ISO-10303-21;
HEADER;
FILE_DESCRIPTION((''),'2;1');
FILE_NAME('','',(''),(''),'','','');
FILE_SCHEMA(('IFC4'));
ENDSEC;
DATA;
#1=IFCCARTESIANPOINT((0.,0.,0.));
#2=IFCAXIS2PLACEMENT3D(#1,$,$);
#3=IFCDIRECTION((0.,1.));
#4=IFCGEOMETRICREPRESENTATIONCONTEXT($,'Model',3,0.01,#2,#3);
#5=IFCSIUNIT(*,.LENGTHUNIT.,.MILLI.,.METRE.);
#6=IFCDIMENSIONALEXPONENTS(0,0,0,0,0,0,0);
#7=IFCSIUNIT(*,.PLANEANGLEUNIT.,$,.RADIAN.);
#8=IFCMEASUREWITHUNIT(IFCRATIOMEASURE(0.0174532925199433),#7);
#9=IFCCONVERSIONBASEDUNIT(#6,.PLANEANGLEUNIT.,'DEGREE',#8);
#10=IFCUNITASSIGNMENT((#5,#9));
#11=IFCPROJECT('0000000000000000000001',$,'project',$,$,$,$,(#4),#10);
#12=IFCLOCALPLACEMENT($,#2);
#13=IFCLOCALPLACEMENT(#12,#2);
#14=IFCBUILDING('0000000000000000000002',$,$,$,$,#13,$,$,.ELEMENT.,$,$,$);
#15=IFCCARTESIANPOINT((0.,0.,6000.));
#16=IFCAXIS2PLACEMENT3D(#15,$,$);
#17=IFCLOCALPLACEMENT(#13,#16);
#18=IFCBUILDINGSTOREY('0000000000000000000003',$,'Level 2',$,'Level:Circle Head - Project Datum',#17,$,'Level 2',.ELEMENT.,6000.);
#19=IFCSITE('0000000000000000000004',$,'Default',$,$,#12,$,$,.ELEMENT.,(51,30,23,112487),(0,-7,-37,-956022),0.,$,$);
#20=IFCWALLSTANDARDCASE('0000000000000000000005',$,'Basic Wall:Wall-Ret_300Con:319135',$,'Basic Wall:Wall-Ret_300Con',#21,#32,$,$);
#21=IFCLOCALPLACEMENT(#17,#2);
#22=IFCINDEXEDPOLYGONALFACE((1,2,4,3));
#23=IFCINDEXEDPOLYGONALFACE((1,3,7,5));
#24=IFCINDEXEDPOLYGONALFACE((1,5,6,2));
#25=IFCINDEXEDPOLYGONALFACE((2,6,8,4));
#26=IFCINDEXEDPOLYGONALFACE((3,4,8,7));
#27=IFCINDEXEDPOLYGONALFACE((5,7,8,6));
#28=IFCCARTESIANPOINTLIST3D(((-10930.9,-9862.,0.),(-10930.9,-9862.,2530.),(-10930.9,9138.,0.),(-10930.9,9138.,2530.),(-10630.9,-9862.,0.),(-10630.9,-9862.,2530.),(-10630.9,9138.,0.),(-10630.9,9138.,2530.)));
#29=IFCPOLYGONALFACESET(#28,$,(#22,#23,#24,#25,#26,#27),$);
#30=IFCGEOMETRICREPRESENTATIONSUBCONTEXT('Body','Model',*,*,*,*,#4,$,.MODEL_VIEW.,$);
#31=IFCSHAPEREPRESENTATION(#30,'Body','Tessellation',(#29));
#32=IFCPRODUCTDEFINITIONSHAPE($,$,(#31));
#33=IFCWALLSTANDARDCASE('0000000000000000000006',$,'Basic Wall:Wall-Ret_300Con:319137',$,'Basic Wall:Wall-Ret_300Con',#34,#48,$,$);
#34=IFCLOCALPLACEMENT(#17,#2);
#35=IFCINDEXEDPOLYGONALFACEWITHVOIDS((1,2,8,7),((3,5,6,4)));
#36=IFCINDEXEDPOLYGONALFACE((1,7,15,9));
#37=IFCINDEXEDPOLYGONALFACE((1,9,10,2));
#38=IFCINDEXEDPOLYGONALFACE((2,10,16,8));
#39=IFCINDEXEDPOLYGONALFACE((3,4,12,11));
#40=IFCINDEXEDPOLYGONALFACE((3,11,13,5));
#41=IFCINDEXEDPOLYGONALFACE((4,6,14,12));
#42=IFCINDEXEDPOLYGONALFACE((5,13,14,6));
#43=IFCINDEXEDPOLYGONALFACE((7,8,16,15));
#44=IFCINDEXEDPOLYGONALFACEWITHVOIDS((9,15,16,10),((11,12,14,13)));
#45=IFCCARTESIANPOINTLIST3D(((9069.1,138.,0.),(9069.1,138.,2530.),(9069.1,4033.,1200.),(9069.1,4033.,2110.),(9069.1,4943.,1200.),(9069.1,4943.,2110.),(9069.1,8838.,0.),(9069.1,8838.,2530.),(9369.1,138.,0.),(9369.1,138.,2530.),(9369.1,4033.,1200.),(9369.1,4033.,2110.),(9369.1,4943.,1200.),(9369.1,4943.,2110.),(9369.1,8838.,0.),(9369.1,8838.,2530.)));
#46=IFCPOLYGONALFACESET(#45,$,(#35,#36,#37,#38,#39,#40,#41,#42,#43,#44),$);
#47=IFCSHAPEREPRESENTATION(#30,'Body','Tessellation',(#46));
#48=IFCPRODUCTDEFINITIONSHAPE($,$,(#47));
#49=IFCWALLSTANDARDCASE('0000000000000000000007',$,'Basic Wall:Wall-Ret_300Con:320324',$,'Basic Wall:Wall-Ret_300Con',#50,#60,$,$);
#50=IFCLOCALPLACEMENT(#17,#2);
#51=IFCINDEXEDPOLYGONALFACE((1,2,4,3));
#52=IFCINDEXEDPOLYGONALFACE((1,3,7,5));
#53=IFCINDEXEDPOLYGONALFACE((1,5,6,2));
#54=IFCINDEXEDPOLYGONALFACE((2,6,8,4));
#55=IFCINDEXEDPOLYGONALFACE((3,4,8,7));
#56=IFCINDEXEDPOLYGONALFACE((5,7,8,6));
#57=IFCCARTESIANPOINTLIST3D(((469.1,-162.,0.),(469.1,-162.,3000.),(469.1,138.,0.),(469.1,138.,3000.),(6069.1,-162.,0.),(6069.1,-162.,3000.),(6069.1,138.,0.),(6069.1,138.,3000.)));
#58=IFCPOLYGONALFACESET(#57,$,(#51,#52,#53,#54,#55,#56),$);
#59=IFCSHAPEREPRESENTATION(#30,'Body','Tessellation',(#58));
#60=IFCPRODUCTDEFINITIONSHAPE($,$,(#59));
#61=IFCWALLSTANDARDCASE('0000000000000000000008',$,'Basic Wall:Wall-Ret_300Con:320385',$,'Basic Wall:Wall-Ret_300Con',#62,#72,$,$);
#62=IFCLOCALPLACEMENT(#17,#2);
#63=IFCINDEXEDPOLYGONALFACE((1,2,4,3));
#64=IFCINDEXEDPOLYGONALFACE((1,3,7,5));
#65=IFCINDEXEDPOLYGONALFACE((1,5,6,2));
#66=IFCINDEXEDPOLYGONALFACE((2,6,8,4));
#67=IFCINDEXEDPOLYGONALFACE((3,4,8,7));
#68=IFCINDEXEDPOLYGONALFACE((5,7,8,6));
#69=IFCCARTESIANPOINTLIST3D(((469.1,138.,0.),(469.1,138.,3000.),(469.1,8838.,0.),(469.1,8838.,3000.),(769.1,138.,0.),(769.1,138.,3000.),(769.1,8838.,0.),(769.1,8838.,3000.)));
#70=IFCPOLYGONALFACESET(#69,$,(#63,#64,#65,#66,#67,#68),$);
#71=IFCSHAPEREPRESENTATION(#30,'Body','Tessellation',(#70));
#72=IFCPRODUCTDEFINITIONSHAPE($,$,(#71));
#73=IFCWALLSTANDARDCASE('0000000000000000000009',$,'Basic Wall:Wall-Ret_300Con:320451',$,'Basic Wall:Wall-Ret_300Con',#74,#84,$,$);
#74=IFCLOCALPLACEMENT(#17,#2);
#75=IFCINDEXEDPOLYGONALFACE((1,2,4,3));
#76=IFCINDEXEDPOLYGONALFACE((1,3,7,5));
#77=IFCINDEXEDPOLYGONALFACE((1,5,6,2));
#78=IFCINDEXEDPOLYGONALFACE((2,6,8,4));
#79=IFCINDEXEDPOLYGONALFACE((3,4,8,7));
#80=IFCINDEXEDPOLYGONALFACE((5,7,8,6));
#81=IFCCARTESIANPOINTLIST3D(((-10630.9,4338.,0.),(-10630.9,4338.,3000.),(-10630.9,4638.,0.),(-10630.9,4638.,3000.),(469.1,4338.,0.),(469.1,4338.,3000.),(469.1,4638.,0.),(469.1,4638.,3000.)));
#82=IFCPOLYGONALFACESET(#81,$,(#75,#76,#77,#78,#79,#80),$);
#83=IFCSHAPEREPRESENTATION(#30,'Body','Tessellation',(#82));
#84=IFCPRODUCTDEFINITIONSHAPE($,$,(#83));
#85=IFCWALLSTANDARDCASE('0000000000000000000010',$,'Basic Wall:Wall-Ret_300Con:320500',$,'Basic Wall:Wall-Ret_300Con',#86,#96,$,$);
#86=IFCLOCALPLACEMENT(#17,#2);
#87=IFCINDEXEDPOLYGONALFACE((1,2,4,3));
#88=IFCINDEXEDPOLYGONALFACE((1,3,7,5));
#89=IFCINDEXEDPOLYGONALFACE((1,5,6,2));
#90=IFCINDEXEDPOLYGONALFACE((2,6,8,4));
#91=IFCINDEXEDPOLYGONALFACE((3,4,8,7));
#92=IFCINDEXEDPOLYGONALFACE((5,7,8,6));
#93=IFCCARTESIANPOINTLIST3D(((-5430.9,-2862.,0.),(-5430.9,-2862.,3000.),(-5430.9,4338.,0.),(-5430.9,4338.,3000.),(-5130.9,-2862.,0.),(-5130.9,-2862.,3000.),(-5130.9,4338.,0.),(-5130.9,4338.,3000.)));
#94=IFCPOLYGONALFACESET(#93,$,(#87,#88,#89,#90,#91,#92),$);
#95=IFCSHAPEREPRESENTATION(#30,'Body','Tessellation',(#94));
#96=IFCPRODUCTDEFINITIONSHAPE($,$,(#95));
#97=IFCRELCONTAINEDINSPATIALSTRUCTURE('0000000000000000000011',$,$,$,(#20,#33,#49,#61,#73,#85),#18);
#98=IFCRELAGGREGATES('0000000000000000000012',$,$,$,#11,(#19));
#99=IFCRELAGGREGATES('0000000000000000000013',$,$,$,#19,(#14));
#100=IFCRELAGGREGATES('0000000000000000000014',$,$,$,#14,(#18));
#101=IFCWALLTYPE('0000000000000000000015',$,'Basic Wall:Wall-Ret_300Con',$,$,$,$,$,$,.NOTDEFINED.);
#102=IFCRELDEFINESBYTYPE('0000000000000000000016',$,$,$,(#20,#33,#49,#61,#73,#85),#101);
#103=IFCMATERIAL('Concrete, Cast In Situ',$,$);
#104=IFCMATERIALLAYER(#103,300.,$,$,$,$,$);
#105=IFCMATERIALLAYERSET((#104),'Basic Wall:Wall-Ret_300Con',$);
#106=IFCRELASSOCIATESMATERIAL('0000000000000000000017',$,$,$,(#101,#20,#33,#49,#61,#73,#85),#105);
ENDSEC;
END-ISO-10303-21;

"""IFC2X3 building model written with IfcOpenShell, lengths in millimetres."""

from ifc_helpers import new_model, entity, si_unit, converted_unit, direction, frame, frame_2d, origin, place, context, subcontext, project, spatial, polyline, rectangle, extrude, clip, bounded_halfspace, material, layer, layer_set, layer_usage, type_object, element, save


model = new_model("IFC2X3")

# Units and contexts
model_context = context("Model", 3, precision=0.01, world=origin(), true_north=direction((0.0, 1.0)))
body_context = subcontext(model_context, "Body", "Model", "MODEL_VIEW")
ifc_project = project(units=[si_unit("LENGTHUNIT", "METRE", prefix="MILLI"), converted_unit("PLANEANGLEUNIT", "DEGREE", entity("IfcRatioMeasure", 0.0174532925199433), si_unit("PLANEANGLEUNIT", "RADIAN"), dimensions=[0, 0, 0, 0, 0, 0, 0])], contexts=[model_context])

# Site, building, storey
site_placement = place(None, origin())
site = spatial("IfcSite", under=ifc_project, at=site_placement, Name="Default", CompositionType="ELEMENT", RefLatitude=(51, 30, 23, 112487), RefLongitude=(0, -7, -37, -956022), RefElevation=0.0)
building_placement = place(site_placement, origin())
building = spatial("IfcBuilding", under=site, at=building_placement, CompositionType="ELEMENT")
storey_placement = place(building_placement, frame((0.0, 0.0, 6000.0)))
storey = spatial("IfcBuildingStorey", under=building, at=storey_placement, Name="Level 2", ObjectType="Level:Circle Head - Project Datum", LongName="Level 2", CompositionType="ELEMENT", Elevation=6000.0)

# Shared definitions
ifc_material = material(Name="Concrete, Cast In Situ")
ifc_layer = layer(ifc_material, 300.0)
ifc_layer_set = layer_set([ifc_layer], Name="Basic Wall:Wall-Ret_300Con")
wall_type = type_object("IfcWallType", Name="Basic Wall:Wall-Ret_300Con", PredefinedType="NOTDEFINED", material=ifc_layer_set)

# Wall
ifc_layer_usage_1 = layer_usage(ifc_layer_set, "AXIS2", "NEGATIVE", 150.0)
wall_1_placement = place(storey_placement, frame((-10780.9, -9862.0, 0.0), z_axis=(0.0, 0.0, 1.0), x_axis=(0.0, 1.0, 0.0)))
element("IfcWallStandardCase", 1, at=wall_1_placement, inside=storey, type_object=wall_type, material=ifc_layer_usage_1, Name="Basic Wall:Wall-Ret_300Con:319135", ObjectType="Basic Wall:Wall-Ret_300Con", context=body_context, shape_type="Clipping", body=[
    clip(extrude(rectangle(XDim=19000.0, YDim=300.0, at=frame_2d((9500.0, 0.0), x_axis=(-1.0, 0.0))), origin(), (0.0, 0.0, 1.0), 2530.0), bounded_halfspace(frame((0.0, -150.0, 2530.0), z_axis=(0.0, 0.0, -1.0), x_axis=(0.0, -1.0, 0.0)), True, frame((0.0, -150.0, 2530.0)), polyline([(0.0, 0.0), (18700.0, 0.0), (18994.8, 0.0), (18994.8, 300.0), (0.0, 300.0), (0.0, 0.0)]))),
])

# Wall, opening
ifc_layer_usage_2 = layer_usage(ifc_layer_set, "AXIS2", "NEGATIVE", 150.0)
wall_2_placement = place(storey_placement, frame((9219.1, 8838.0, 0.0), z_axis=(0.0, 0.0, 1.0), x_axis=(0.0, -1.0, 0.0)))
wall_2 = element("IfcWallStandardCase", 2, at=wall_2_placement, inside=storey, type_object=wall_type, material=ifc_layer_usage_2, Name="Basic Wall:Wall-Ret_300Con:319137", ObjectType="Basic Wall:Wall-Ret_300Con", context=body_context, shape_type="Clipping", body=[
    clip(extrude(rectangle(XDim=8700.0, YDim=300.0, at=frame_2d((4350.0, 0.0), x_axis=(-1.0, 0.0))), origin(), (0.0, 0.0, 1.0), 2530.0), bounded_halfspace(frame((0.0, -150.0, 2530.0), z_axis=(0.0, 0.0, -1.0), x_axis=(0.0, 1.0, 0.0)), True, frame((0.0, -150.0, 2530.0)), polyline([(0.0, 0.0), (8700.0, 0.0), (8700.0, 280.1), (0.0, 280.1), (0.0, 0.0)]))),
])
opening_1_placement = place(wall_2_placement, frame((3895.0, -150.0, 1200.0)))
element("IfcOpeningElement", 3, at=opening_1_placement, cuts=wall_2, ObjectType="Opening", context=body_context, shape_type="SweptSolid", body=[
    extrude(rectangle(XDim=910.0, YDim=910.0, at=frame_2d((455.0, 455.0), x_axis=(-1.0, 0.0))), frame((0.0, 0.0, 0.0), z_axis=(0.0, 1.0, 0.0), x_axis=(0.0, 0.0, 1.0)), (0.0, 0.0, 1.0), 300.0),
])

# Walls
ifc_layer_usage_3 = layer_usage(ifc_layer_set, "AXIS2", "NEGATIVE", 150.0)
wall_3_placement = place(storey_placement, frame((6069.1, -12.0, 0.0), z_axis=(0.0, 0.0, 1.0), x_axis=(-1.0, 0.0, 0.0)))
element("IfcWallStandardCase", 4, at=wall_3_placement, inside=storey, type_object=wall_type, material=ifc_layer_usage_3, Name="Basic Wall:Wall-Ret_300Con:320324", ObjectType="Basic Wall:Wall-Ret_300Con", context=body_context, shape_type="SweptSolid", body=[
    extrude(rectangle(XDim=5600.0, YDim=300.0, at=frame_2d((2800.0, 0.0), x_axis=(-1.0, 0.0))), origin(), (0.0, 0.0, 1.0), 3000.0),
])
ifc_layer_usage_4 = layer_usage(ifc_layer_set, "AXIS2", "NEGATIVE", 150.0)
wall_4_placement = place(storey_placement, frame((619.1, 138.0, 0.0), z_axis=(0.0, 0.0, 1.0), x_axis=(0.0, 1.0, 0.0)))
element("IfcWallStandardCase", 5, at=wall_4_placement, inside=storey, type_object=wall_type, material=ifc_layer_usage_4, Name="Basic Wall:Wall-Ret_300Con:320385", ObjectType="Basic Wall:Wall-Ret_300Con", context=body_context, shape_type="SweptSolid", body=[
    extrude(rectangle(XDim=8700.0, YDim=300.0, at=frame_2d((4350.0, 0.0), x_axis=(-1.0, 0.0))), origin(), (0.0, 0.0, 1.0), 3000.0),
])
ifc_layer_usage_5 = layer_usage(ifc_layer_set, "AXIS2", "NEGATIVE", 150.0)
wall_5_placement = place(storey_placement, frame((469.1, 4488.0, 0.0), z_axis=(0.0, 0.0, 1.0), x_axis=(-1.0, 0.0, 0.0)))
element("IfcWallStandardCase", 6, at=wall_5_placement, inside=storey, type_object=wall_type, material=ifc_layer_usage_5, Name="Basic Wall:Wall-Ret_300Con:320451", ObjectType="Basic Wall:Wall-Ret_300Con", context=body_context, shape_type="SweptSolid", body=[
    extrude(rectangle(XDim=11100.0, YDim=300.0, at=frame_2d((5550.0, 0.0), x_axis=(-1.0, 0.0))), origin(), (0.0, 0.0, 1.0), 3000.0),
])
ifc_layer_usage_6 = layer_usage(ifc_layer_set, "AXIS2", "NEGATIVE", 150.0)
wall_6_placement = place(storey_placement, frame((-5280.9, -2862.0, 0.0), z_axis=(0.0, 0.0, 1.0), x_axis=(0.0, 1.0, 0.0)))
element("IfcWallStandardCase", 7, at=wall_6_placement, inside=storey, type_object=wall_type, material=ifc_layer_usage_6, Name="Basic Wall:Wall-Ret_300Con:320500", ObjectType="Basic Wall:Wall-Ret_300Con", context=body_context, shape_type="SweptSolid", body=[
    extrude(rectangle(XDim=7200.0, YDim=300.0, at=frame_2d((3600.0, 0.0), x_axis=(-1.0, 0.0))), origin(), (0.0, 0.0, 1.0), 3000.0),
])

save(model, "model.ifc")
